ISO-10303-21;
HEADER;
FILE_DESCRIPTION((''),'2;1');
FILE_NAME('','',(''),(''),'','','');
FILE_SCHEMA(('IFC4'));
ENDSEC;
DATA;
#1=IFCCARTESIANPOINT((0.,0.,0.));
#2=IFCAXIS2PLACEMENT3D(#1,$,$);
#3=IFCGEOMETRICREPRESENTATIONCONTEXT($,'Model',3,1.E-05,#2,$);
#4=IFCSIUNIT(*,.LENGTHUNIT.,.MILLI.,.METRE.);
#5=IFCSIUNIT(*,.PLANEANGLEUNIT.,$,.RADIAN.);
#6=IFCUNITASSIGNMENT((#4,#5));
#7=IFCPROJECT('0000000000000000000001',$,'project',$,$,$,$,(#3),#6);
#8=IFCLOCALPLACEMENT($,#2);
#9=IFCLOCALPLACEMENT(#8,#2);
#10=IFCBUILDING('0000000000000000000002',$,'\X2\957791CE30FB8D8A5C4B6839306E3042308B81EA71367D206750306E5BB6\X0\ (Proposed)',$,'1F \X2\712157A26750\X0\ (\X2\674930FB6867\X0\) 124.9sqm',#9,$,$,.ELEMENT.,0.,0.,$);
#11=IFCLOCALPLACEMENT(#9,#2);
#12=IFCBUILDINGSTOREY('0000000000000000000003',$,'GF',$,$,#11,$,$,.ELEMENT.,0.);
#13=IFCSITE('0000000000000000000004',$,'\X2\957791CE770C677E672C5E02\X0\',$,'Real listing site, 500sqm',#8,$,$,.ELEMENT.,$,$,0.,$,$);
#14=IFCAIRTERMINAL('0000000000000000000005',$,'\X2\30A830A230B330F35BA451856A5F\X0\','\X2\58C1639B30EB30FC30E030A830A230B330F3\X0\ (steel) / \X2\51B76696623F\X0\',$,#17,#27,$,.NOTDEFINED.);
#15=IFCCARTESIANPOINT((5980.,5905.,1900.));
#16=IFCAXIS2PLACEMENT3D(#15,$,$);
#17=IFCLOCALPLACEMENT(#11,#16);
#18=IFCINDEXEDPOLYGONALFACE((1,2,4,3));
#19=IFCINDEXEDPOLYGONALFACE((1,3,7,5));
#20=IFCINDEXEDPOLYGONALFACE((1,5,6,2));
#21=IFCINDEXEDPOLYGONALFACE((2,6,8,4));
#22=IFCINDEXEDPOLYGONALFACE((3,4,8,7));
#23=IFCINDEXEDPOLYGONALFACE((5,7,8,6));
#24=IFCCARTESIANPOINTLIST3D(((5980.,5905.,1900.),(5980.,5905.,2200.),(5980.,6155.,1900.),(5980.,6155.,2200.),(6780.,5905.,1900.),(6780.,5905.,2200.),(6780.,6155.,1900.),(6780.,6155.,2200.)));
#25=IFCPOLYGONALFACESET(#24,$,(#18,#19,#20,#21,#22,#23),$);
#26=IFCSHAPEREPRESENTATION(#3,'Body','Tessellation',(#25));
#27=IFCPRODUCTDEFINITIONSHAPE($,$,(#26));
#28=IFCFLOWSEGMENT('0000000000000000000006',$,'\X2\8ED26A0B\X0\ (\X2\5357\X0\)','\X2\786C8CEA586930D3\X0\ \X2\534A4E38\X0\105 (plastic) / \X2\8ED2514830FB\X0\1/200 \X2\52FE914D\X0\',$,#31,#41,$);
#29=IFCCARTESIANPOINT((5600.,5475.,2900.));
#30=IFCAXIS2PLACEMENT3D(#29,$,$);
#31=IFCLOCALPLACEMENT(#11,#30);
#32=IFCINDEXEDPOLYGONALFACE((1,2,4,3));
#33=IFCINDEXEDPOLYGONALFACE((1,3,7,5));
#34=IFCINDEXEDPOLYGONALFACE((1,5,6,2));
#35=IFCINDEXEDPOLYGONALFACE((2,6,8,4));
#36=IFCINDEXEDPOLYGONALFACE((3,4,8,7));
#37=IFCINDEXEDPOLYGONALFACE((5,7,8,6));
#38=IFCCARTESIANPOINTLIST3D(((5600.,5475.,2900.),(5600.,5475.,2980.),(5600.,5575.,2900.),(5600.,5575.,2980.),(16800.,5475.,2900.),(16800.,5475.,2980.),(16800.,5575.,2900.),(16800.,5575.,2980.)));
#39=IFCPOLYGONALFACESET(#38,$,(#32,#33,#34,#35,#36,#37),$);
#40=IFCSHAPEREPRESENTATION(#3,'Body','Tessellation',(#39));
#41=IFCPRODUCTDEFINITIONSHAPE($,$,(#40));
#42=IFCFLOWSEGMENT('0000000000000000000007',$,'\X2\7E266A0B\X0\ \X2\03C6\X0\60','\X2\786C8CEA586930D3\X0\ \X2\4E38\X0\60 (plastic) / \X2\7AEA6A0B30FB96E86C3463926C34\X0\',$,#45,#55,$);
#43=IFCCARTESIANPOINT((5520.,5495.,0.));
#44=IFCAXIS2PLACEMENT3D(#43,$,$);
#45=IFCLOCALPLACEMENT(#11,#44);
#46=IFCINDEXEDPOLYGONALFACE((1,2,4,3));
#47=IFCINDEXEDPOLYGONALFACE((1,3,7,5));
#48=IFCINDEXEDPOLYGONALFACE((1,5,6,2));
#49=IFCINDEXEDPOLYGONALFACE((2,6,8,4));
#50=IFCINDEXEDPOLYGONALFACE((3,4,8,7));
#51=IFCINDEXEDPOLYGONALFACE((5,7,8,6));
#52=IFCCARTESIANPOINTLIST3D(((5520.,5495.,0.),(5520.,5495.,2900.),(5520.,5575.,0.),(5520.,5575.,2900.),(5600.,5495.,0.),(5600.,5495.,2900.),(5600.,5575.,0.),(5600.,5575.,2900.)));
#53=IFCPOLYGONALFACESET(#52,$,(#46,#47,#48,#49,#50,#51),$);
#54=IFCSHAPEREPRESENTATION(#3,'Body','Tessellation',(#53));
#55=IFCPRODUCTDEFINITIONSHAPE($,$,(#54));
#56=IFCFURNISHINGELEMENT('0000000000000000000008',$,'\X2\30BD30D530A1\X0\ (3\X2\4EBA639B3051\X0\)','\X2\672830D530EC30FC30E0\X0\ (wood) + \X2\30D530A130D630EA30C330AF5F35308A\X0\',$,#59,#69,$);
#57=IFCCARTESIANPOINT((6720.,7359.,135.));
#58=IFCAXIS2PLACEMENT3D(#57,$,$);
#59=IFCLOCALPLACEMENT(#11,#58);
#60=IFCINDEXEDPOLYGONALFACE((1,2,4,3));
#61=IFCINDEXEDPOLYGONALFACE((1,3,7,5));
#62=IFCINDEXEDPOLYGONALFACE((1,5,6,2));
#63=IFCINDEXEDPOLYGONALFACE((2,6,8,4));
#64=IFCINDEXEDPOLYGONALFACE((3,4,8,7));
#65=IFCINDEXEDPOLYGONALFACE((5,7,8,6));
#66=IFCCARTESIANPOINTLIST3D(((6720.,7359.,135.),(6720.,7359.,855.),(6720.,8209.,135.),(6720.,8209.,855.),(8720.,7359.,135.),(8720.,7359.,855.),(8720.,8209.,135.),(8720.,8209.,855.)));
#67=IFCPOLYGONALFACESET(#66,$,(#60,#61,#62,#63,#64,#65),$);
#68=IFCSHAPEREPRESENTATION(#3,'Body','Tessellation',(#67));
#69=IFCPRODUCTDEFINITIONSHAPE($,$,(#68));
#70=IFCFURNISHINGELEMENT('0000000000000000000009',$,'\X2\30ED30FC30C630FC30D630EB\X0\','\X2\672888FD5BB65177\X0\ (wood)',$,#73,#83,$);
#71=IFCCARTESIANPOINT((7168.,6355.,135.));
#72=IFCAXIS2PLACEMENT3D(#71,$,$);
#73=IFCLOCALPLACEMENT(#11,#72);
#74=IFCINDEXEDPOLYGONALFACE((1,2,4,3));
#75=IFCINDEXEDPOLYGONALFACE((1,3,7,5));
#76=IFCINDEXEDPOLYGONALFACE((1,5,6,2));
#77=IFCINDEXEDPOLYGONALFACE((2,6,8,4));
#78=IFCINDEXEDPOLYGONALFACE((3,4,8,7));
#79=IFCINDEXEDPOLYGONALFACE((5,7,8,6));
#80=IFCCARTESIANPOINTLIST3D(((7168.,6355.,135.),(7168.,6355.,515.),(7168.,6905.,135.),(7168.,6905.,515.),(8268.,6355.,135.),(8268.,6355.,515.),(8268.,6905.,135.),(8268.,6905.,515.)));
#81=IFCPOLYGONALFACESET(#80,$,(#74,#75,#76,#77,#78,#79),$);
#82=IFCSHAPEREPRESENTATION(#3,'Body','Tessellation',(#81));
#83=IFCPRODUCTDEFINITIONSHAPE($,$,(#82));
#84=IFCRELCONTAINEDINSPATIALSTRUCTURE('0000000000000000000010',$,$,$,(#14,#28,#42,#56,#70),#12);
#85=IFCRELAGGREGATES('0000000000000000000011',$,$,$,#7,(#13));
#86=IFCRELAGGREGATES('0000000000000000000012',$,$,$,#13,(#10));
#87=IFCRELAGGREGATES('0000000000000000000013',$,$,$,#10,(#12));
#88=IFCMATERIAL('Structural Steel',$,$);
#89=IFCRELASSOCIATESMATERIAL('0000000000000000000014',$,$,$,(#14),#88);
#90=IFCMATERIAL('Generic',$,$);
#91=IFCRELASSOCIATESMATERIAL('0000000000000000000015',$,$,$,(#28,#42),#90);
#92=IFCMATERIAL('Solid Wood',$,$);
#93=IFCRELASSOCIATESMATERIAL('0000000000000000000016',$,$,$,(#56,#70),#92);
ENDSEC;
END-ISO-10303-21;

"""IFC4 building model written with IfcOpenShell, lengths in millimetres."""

from ifc_helpers import new_model, si_unit, frame, frame_2d, origin, place, context, project, spatial, rectangle, extrude, material, element, save


model = new_model("IFC4")

# Units and contexts
model_context = context("Model", 3, precision=1e-05, world=origin())
ifc_project = project(units=[si_unit("LENGTHUNIT", "METRE", prefix="MILLI"), si_unit("PLANEANGLEUNIT", "RADIAN")], contexts=[model_context])

# Site, building, storey
site_placement = place(None, origin())
site = spatial("IfcSite", under=ifc_project, at=site_placement, Name="長野県松本市", ObjectType="Real listing site, 500sqm", CompositionType="ELEMENT", RefElevation=0.0)
building_placement = place(site_placement, origin())
building = spatial("IfcBuilding", under=site, at=building_placement, Name="長野・越屋根のある自然素材の家 (Proposed)", ObjectType="1F 無垢材 (杉・桧) 124.9sqm", CompositionType="ELEMENT", ElevationOfRefHeight=0.0, ElevationOfTerrain=0.0)
storey_placement = place(building_placement, origin())
storey = spatial("IfcBuildingStorey", under=building, at=storey_placement, Name="GF", CompositionType="ELEMENT", Elevation=0.0)

# Shared definitions
ifc_material_1 = material(Name="Solid Wood")

# Shared definitions
ifc_material_2 = material(Name="Structural Steel")

# Shared definitions
ifc_material_3 = material(Name="Generic")

# Air terminal
air_terminal_placement = place(storey_placement, frame((5980.0, 5905.0, 1900.0)))
element("IfcAirTerminal", 1, at=air_terminal_placement, inside=storey, material=ifc_material_2, Name="エアコン室内機", Description="壁掛ルームエアコン (steel) / 冷暖房", PredefinedType="NOTDEFINED", context=model_context, shape_type="SweptSolid", body=[
    extrude(rectangle(XDim=800.0, YDim=250.0, at=frame_2d((400.0, 125.0))), frame((5980.0, 5905.0, 1900.0)), (0.0, 0.0, 1.0), 300.0),
])

# Flow segments
flow_segment_1_placement = place(storey_placement, frame((5600.0, 5475.0, 2900.0)))
element("IfcFlowSegment", 2, at=flow_segment_1_placement, inside=storey, material=ifc_material_3, Name="軒樋 (南)", Description="硬質塩ビ 半丸105 (plastic) / 軒先・1/200 勾配", context=model_context, shape_type="SweptSolid", body=[
    extrude(rectangle(XDim=11200.0, YDim=100.0, at=frame_2d((5600.0, 50.0))), frame((5600.0, 5475.0, 2900.0)), (0.0, 0.0, 1.0), 80.0),
])
flow_segment_2_placement = place(storey_placement, frame((5520.0, 5495.0, 0.0)))
element("IfcFlowSegment", 3, at=flow_segment_2_placement, inside=storey, material=ifc_material_3, Name="縦樋 φ60", Description="硬質塩ビ 丸60 (plastic) / 竪樋・雨水排水", context=model_context, shape_type="SweptSolid", body=[
    extrude(rectangle(XDim=80.0, YDim=80.0, at=frame_2d((40.0, 40.0))), frame((5520.0, 5495.0, 0.0)), (0.0, 0.0, 1.0), 2900.0),
])

# Furnishing elements
furnishing_1_placement = place(storey_placement, frame((6720.0, 7359.0, 135.0)))
element("IfcFurnishingElement", 4, at=furnishing_1_placement, inside=storey, material=ifc_material_1, Name="ソファ (3人掛け)", Description="木フレーム (wood) + ファブリック張り", context=model_context, shape_type="SweptSolid", body=[
    extrude(rectangle(XDim=2000.0, YDim=850.0, at=frame_2d((1000.0, 425.0))), frame((6720.0, 7359.0, 135.0)), (0.0, 0.0, 1.0), 720.0),
])
furnishing_2_placement = place(storey_placement, frame((7168.0, 6355.0, 135.0)))
element("IfcFurnishingElement", 5, at=furnishing_2_placement, inside=storey, material=ifc_material_1, Name="ローテーブル", Description="木製家具 (wood)", context=model_context, shape_type="SweptSolid", body=[
    extrude(rectangle(XDim=1100.0, YDim=550.0, at=frame_2d((550.0, 275.0))), frame((7168.0, 6355.0, 135.0)), (0.0, 0.0, 1.0), 380.0),
])

save(model, "model.ifc")
